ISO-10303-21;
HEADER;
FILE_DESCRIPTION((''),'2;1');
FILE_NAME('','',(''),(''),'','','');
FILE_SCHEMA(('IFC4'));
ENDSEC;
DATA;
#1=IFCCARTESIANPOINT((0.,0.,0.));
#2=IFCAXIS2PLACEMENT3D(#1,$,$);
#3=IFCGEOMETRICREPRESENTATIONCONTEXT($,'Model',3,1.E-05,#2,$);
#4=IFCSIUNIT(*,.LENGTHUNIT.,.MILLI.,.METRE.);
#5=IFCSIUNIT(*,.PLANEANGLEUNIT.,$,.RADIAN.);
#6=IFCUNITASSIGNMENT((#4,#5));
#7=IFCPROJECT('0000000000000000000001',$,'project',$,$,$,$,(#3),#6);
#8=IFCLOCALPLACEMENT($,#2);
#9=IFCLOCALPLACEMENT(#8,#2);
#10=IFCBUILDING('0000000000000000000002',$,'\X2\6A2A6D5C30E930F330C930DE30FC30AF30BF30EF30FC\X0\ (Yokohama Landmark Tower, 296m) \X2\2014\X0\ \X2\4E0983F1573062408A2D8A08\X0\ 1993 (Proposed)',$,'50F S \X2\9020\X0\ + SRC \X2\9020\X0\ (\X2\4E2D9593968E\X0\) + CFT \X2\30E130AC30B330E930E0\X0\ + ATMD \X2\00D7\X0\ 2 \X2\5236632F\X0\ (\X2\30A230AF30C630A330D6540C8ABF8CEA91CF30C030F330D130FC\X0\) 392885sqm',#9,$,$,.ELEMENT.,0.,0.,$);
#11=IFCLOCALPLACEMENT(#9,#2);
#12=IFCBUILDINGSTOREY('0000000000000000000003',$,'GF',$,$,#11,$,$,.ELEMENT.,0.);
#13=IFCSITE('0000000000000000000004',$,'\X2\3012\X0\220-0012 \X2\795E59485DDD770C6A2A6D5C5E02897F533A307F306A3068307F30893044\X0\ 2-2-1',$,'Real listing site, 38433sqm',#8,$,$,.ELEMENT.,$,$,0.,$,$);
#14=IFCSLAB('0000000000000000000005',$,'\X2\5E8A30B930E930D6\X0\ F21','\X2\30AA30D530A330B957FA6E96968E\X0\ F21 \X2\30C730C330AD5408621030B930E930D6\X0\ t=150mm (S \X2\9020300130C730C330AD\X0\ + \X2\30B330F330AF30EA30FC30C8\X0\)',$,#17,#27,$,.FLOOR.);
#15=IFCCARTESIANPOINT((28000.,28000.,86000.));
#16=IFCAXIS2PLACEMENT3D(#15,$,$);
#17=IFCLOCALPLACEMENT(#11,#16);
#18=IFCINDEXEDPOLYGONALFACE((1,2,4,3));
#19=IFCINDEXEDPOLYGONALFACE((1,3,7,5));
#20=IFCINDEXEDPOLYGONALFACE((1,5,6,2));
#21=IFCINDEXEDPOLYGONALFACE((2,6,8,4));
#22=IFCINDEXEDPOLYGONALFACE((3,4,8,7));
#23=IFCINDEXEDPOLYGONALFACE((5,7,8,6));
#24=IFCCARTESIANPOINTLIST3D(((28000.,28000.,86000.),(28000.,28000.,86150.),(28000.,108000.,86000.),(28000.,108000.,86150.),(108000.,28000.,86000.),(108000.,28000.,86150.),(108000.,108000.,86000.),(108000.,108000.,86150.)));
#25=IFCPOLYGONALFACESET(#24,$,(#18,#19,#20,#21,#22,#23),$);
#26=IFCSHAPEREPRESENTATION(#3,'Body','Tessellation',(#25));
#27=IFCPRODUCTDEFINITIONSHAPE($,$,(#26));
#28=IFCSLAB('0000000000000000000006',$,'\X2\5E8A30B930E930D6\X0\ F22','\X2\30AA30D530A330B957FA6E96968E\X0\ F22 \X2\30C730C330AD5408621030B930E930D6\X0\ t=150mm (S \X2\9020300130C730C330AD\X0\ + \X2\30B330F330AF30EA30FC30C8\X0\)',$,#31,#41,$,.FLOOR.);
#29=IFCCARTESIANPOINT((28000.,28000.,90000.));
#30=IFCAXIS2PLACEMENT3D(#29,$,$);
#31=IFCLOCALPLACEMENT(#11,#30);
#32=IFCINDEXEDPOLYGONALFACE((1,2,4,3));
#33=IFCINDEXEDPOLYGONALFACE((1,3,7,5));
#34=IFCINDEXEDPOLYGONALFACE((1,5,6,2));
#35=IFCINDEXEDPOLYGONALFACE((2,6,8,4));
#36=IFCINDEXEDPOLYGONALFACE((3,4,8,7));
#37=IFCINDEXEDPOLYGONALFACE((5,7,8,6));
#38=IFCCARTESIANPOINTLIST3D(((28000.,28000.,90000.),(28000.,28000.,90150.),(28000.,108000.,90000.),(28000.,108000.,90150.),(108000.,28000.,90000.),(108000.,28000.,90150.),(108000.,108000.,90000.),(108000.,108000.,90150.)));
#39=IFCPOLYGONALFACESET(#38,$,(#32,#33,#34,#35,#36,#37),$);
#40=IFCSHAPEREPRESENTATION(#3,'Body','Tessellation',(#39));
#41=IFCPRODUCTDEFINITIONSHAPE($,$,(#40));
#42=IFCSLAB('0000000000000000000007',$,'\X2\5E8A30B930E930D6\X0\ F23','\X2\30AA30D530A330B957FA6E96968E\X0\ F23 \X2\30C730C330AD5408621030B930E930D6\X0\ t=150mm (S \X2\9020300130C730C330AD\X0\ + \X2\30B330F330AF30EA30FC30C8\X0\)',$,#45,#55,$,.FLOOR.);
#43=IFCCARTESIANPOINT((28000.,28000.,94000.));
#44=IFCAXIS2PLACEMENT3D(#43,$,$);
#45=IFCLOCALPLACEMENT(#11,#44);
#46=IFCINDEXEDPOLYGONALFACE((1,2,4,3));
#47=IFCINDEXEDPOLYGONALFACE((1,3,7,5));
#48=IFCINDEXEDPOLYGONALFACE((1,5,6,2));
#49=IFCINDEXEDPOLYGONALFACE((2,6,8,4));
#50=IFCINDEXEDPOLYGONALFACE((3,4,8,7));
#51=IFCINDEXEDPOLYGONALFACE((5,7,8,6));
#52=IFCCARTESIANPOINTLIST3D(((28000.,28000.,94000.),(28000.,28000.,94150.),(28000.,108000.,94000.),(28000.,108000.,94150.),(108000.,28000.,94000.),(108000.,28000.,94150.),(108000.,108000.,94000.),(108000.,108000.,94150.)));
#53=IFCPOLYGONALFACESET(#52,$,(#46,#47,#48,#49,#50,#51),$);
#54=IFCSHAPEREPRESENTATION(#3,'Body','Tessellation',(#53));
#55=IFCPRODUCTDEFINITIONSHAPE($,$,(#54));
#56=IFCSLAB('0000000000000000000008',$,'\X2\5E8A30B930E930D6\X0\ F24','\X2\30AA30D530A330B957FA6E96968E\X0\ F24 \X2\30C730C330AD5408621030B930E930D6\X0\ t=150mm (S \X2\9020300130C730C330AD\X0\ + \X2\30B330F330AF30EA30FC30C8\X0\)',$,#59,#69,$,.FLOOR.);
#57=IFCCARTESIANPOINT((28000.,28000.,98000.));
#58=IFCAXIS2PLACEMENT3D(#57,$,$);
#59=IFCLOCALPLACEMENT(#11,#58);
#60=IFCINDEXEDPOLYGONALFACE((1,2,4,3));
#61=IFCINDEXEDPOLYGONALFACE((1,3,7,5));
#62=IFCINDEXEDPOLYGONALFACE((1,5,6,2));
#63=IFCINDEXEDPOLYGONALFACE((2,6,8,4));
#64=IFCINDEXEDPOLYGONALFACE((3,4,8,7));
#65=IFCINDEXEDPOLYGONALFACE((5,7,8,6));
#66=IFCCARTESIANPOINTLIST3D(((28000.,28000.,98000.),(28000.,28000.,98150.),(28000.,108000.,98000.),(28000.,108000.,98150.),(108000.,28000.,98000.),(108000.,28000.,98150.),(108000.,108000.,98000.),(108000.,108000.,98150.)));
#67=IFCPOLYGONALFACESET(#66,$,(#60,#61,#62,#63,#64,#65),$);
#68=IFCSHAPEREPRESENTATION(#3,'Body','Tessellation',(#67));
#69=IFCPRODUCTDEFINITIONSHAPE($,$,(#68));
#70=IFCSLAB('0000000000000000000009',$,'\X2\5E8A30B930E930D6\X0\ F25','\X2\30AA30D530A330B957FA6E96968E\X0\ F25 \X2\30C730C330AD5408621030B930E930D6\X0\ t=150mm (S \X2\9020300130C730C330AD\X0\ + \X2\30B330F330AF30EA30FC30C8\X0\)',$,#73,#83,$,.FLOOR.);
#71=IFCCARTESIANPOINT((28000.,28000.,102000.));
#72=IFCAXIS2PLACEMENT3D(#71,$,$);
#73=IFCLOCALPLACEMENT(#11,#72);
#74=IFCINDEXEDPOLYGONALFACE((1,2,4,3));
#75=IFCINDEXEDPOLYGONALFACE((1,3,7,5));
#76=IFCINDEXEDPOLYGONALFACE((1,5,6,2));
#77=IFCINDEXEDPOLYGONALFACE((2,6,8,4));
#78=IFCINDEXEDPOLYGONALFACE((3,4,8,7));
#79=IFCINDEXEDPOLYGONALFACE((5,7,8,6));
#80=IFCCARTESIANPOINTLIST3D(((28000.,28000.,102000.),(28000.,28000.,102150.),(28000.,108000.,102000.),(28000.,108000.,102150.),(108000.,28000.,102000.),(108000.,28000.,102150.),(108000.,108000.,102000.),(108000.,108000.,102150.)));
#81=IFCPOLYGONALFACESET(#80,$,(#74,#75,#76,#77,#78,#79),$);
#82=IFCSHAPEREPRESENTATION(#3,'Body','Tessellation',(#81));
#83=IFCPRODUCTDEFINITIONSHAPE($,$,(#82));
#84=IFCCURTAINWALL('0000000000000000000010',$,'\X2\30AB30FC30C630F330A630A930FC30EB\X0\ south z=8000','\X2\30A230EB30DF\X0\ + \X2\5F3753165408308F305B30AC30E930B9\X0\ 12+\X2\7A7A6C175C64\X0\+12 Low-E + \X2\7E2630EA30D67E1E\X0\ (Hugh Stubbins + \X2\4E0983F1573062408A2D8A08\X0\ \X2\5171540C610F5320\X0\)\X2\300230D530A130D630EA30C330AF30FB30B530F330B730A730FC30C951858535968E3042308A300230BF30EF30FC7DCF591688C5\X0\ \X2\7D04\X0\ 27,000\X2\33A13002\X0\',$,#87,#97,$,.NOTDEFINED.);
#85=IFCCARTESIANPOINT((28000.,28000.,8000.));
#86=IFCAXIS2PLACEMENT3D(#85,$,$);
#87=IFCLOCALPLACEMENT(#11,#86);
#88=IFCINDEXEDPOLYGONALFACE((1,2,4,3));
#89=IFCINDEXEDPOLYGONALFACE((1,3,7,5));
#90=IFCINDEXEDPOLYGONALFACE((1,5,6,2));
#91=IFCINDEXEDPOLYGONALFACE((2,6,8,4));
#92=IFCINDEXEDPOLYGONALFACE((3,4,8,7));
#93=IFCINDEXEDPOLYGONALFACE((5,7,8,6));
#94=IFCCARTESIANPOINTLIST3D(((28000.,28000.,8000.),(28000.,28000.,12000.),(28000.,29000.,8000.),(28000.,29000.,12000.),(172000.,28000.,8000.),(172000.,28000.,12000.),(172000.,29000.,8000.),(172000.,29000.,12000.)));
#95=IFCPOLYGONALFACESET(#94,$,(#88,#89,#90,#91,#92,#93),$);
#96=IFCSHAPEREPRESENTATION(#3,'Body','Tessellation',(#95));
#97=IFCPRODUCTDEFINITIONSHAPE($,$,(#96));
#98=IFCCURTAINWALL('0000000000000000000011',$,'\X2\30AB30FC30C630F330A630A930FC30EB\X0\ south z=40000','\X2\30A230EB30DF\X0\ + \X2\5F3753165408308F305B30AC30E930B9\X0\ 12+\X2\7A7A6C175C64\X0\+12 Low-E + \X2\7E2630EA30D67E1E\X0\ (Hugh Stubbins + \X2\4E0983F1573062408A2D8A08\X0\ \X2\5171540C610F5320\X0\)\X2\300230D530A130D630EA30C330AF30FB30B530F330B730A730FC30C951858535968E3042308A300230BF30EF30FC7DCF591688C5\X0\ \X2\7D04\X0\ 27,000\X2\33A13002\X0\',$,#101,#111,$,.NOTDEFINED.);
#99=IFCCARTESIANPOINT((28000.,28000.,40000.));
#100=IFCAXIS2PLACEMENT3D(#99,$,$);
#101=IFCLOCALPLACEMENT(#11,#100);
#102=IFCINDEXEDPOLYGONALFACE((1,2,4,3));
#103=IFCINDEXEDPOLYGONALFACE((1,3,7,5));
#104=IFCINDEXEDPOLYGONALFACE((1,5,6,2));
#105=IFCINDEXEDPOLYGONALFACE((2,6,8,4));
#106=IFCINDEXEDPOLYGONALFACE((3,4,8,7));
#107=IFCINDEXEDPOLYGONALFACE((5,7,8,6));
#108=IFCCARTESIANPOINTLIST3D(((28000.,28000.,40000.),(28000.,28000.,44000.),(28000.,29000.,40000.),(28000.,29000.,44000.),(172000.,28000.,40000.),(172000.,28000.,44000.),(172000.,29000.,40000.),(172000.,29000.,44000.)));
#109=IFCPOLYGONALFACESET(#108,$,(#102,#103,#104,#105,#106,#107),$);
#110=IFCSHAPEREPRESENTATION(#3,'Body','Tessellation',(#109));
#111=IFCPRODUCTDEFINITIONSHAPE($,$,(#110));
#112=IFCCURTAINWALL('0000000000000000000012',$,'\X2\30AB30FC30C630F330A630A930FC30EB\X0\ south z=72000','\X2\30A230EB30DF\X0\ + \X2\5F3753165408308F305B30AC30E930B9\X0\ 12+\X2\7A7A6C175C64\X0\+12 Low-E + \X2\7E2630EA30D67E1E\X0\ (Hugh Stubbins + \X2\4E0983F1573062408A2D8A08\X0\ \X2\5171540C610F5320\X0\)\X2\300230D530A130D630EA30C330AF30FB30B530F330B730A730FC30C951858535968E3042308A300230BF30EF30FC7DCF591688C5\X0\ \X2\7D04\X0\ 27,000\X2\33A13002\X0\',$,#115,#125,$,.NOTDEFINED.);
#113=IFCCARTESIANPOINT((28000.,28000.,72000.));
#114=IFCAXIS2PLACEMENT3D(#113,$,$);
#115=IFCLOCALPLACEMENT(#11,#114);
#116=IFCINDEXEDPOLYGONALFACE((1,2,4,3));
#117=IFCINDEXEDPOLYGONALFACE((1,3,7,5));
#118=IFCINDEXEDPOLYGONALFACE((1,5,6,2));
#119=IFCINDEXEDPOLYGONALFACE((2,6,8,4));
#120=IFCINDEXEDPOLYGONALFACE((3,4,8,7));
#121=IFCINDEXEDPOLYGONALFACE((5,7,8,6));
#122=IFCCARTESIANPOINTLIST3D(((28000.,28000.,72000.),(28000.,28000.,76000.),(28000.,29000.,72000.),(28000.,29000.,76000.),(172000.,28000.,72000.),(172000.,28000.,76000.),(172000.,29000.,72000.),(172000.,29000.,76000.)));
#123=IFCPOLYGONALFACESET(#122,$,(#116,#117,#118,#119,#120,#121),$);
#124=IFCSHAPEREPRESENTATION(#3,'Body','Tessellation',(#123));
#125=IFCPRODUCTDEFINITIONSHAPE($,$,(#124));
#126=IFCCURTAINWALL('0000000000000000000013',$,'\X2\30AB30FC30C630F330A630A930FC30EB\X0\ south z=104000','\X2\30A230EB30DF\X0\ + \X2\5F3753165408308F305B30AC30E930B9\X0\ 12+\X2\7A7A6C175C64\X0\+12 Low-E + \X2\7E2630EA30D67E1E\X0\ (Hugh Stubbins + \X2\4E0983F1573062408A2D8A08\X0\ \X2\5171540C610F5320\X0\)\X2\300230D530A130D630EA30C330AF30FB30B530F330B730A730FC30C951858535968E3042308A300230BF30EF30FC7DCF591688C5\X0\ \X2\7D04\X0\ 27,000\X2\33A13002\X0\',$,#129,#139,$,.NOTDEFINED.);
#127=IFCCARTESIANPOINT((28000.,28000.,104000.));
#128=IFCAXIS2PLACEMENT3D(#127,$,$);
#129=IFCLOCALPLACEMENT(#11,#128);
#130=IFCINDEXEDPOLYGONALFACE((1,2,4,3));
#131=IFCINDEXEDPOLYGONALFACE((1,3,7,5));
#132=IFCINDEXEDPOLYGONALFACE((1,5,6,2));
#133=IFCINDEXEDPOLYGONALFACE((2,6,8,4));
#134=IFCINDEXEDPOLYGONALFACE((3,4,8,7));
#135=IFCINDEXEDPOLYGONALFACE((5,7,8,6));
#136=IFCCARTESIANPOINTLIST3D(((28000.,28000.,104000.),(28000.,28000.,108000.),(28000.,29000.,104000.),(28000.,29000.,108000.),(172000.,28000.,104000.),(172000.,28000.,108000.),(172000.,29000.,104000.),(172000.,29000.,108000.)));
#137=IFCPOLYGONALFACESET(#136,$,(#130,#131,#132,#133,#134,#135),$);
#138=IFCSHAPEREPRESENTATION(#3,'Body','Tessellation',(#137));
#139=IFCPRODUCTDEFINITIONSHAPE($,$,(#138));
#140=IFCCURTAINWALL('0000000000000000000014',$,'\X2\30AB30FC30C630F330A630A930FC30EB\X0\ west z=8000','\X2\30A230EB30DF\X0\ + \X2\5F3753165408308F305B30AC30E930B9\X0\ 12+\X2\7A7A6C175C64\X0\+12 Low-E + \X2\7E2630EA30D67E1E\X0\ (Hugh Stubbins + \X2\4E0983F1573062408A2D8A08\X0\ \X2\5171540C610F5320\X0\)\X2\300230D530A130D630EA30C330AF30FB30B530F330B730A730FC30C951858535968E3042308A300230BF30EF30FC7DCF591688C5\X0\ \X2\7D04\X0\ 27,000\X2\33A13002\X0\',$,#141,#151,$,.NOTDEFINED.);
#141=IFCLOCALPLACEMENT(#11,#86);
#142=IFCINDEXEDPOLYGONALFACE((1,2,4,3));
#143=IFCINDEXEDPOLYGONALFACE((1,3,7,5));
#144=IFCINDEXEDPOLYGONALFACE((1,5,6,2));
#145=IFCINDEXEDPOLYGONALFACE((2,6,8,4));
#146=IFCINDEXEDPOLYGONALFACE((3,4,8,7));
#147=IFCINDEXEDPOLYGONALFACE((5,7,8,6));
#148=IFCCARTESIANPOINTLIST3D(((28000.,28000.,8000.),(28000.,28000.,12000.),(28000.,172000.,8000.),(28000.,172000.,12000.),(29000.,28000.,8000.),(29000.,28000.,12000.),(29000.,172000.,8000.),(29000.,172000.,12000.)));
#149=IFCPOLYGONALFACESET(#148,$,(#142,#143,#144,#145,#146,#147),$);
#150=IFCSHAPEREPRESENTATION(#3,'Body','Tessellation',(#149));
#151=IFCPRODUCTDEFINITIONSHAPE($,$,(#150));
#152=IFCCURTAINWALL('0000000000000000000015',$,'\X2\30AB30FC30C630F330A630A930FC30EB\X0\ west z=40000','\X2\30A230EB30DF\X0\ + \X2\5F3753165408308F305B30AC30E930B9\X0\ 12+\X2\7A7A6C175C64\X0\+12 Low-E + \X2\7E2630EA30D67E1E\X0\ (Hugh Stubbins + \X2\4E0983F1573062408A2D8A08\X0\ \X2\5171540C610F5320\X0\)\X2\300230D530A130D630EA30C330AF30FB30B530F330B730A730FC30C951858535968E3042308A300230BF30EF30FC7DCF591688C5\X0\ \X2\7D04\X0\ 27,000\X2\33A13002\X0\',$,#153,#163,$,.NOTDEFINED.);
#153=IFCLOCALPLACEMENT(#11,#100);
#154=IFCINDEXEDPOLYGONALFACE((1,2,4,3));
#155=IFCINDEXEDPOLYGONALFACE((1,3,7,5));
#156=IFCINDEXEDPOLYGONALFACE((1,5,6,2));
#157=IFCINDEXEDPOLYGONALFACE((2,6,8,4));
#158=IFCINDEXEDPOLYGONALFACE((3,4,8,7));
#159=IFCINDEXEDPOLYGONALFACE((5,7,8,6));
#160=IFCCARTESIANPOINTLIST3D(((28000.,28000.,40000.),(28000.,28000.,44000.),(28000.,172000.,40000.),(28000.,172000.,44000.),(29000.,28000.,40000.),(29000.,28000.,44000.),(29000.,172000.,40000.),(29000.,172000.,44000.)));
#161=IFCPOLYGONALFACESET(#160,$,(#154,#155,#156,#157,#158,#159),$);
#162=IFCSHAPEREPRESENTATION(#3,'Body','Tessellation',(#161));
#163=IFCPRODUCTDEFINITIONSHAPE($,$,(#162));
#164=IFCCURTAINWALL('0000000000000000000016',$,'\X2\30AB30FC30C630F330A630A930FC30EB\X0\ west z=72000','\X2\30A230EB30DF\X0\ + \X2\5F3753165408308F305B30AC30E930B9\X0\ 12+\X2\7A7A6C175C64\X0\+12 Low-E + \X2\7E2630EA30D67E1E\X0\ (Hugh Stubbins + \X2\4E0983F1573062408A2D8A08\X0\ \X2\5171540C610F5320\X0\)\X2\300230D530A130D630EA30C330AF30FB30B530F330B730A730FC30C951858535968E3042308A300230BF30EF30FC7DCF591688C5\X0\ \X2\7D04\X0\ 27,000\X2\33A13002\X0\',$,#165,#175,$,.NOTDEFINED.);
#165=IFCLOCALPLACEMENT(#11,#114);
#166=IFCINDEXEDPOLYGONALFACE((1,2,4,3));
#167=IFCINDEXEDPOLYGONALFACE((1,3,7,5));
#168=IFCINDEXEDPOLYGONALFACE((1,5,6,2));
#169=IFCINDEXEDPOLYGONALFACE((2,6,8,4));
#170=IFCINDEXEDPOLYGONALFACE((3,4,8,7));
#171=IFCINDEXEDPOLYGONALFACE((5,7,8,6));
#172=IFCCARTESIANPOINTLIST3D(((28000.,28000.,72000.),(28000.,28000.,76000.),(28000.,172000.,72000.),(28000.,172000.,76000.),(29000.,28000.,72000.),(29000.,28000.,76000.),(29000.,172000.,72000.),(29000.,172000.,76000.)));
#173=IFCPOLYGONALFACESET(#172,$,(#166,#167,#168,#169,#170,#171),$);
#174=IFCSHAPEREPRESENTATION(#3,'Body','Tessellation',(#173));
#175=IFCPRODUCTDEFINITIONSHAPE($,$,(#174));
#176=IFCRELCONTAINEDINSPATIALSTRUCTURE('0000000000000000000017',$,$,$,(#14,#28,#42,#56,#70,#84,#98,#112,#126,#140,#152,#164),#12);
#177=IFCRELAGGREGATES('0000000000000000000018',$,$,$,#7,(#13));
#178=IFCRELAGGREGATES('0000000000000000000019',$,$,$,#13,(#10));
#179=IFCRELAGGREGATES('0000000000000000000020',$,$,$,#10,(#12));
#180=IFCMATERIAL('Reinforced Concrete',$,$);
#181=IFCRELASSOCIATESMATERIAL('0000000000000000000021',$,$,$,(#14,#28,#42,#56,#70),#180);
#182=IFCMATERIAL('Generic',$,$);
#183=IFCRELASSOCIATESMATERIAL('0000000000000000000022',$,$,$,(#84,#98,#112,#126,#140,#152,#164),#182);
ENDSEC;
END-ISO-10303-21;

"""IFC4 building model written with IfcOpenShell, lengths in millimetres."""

from ifc_helpers import new_model, si_unit, frame, frame_2d, origin, place, context, project, spatial, rectangle, extrude, material, element, save


model = new_model("IFC4")

# Units and contexts
model_context = context("Model", 3, precision=1e-05, world=origin())
ifc_project = project(units=[si_unit("LENGTHUNIT", "METRE", prefix="MILLI"), si_unit("PLANEANGLEUNIT", "RADIAN")], contexts=[model_context])

# Site, building, storey
site_placement = place(None, origin())
site = spatial("IfcSite", under=ifc_project, at=site_placement, Name="〒220-0012 神奈川県横浜市西区みなとみらい 2-2-1", ObjectType="Real listing site, 38433sqm", CompositionType="ELEMENT", RefElevation=0.0)
building_placement = place(site_placement, origin())
building = spatial("IfcBuilding", under=site, at=building_placement, Name="横浜ランドマークタワー (Yokohama Landmark Tower, 296m) — 三菱地所設計 1993 (Proposed)", ObjectType="50F S 造 + SRC 造 (中間階) + CFT メガコラム + ATMD × 2 制振 (アクティブ同調質量ダンパー) 392885sqm", CompositionType="ELEMENT", ElevationOfRefHeight=0.0, ElevationOfTerrain=0.0)
storey_placement = place(building_placement, origin())
storey = spatial("IfcBuildingStorey", under=building, at=storey_placement, Name="GF", CompositionType="ELEMENT", Elevation=0.0)

# Shared definitions
ifc_material_1 = material(Name="Reinforced Concrete")

# Slabs
slab_1_placement = place(storey_placement, frame((28000.0, 28000.0, 86000.0)))
element("IfcSlab", 1, at=slab_1_placement, inside=storey, material=ifc_material_1, Name="床スラブ F21", Description="オフィス基準階 F21 デッキ合成スラブ t=150mm (S 造、デッキ + コンクリート)", PredefinedType="FLOOR", context=model_context, shape_type="SweptSolid", body=[
    extrude(rectangle(XDim=80000.0, YDim=80000.0, at=frame_2d((40000.0, 40000.0))), frame((28000.0, 28000.0, 86000.0)), (0.0, 0.0, 1.0), 150.0),
])
slab_2_placement = place(storey_placement, frame((28000.0, 28000.0, 90000.0)))
element("IfcSlab", 2, at=slab_2_placement, inside=storey, material=ifc_material_1, Name="床スラブ F22", Description="オフィス基準階 F22 デッキ合成スラブ t=150mm (S 造、デッキ + コンクリート)", PredefinedType="FLOOR", context=model_context, shape_type="SweptSolid", body=[
    extrude(rectangle(XDim=80000.0, YDim=80000.0, at=frame_2d((40000.0, 40000.0))), frame((28000.0, 28000.0, 90000.0)), (0.0, 0.0, 1.0), 150.0),
])
slab_3_placement = place(storey_placement, frame((28000.0, 28000.0, 94000.0)))
element("IfcSlab", 3, at=slab_3_placement, inside=storey, material=ifc_material_1, Name="床スラブ F23", Description="オフィス基準階 F23 デッキ合成スラブ t=150mm (S 造、デッキ + コンクリート)", PredefinedType="FLOOR", context=model_context, shape_type="SweptSolid", body=[
    extrude(rectangle(XDim=80000.0, YDim=80000.0, at=frame_2d((40000.0, 40000.0))), frame((28000.0, 28000.0, 94000.0)), (0.0, 0.0, 1.0), 150.0),
])
slab_4_placement = place(storey_placement, frame((28000.0, 28000.0, 98000.0)))
element("IfcSlab", 4, at=slab_4_placement, inside=storey, material=ifc_material_1, Name="床スラブ F24", Description="オフィス基準階 F24 デッキ合成スラブ t=150mm (S 造、デッキ + コンクリート)", PredefinedType="FLOOR", context=model_context, shape_type="SweptSolid", body=[
    extrude(rectangle(XDim=80000.0, YDim=80000.0, at=frame_2d((40000.0, 40000.0))), frame((28000.0, 28000.0, 98000.0)), (0.0, 0.0, 1.0), 150.0),
])
slab_5_placement = place(storey_placement, frame((28000.0, 28000.0, 102000.0)))
element("IfcSlab", 5, at=slab_5_placement, inside=storey, material=ifc_material_1, Name="床スラブ F25", Description="オフィス基準階 F25 デッキ合成スラブ t=150mm (S 造、デッキ + コンクリート)", PredefinedType="FLOOR", context=model_context, shape_type="SweptSolid", body=[
    extrude(rectangle(XDim=80000.0, YDim=80000.0, at=frame_2d((40000.0, 40000.0))), frame((28000.0, 28000.0, 102000.0)), (0.0, 0.0, 1.0), 150.0),
])

# Curtain walls
ifc_material_2 = material(Name="Generic")
curtain_wall_1_placement = place(storey_placement, frame((28000.0, 28000.0, 8000.0)))
element("IfcCurtainWall", 6, at=curtain_wall_1_placement, inside=storey, material=ifc_material_2, Name="カーテンウォール south z=8000", Description="アルミ + 強化合わせガラス 12+空気層+12 Low-E + 縦リブ縞 (Hugh Stubbins + 三菱地所設計 共同意匠)。ファブリック・サンシェード内蔵階あり。タワー総外装 約 27,000㎡。", PredefinedType="NOTDEFINED", context=model_context, shape_type="SweptSolid", body=[
    extrude(rectangle(XDim=144000.0, YDim=1000.0, at=frame_2d((72000.0, 500.0))), frame((28000.0, 28000.0, 8000.0)), (0.0, 0.0, 1.0), 4000.0),
])
curtain_wall_2_placement = place(storey_placement, frame((28000.0, 28000.0, 40000.0)))
element("IfcCurtainWall", 7, at=curtain_wall_2_placement, inside=storey, material=ifc_material_2, Name="カーテンウォール south z=40000", Description="アルミ + 強化合わせガラス 12+空気層+12 Low-E + 縦リブ縞 (Hugh Stubbins + 三菱地所設計 共同意匠)。ファブリック・サンシェード内蔵階あり。タワー総外装 約 27,000㎡。", PredefinedType="NOTDEFINED", context=model_context, shape_type="SweptSolid", body=[
    extrude(rectangle(XDim=144000.0, YDim=1000.0, at=frame_2d((72000.0, 500.0))), frame((28000.0, 28000.0, 40000.0)), (0.0, 0.0, 1.0), 4000.0),
])
curtain_wall_3_placement = place(storey_placement, frame((28000.0, 28000.0, 72000.0)))
element("IfcCurtainWall", 8, at=curtain_wall_3_placement, inside=storey, material=ifc_material_2, Name="カーテンウォール south z=72000", Description="アルミ + 強化合わせガラス 12+空気層+12 Low-E + 縦リブ縞 (Hugh Stubbins + 三菱地所設計 共同意匠)。ファブリック・サンシェード内蔵階あり。タワー総外装 約 27,000㎡。", PredefinedType="NOTDEFINED", context=model_context, shape_type="SweptSolid", body=[
    extrude(rectangle(XDim=144000.0, YDim=1000.0, at=frame_2d((72000.0, 500.0))), frame((28000.0, 28000.0, 72000.0)), (0.0, 0.0, 1.0), 4000.0),
])
curtain_wall_4_placement = place(storey_placement, frame((28000.0, 28000.0, 104000.0)))
element("IfcCurtainWall", 9, at=curtain_wall_4_placement, inside=storey, material=ifc_material_2, Name="カーテンウォール south z=104000", Description="アルミ + 強化合わせガラス 12+空気層+12 Low-E + 縦リブ縞 (Hugh Stubbins + 三菱地所設計 共同意匠)。ファブリック・サンシェード内蔵階あり。タワー総外装 約 27,000㎡。", PredefinedType="NOTDEFINED", context=model_context, shape_type="SweptSolid", body=[
    extrude(rectangle(XDim=144000.0, YDim=1000.0, at=frame_2d((72000.0, 500.0))), frame((28000.0, 28000.0, 104000.0)), (0.0, 0.0, 1.0), 4000.0),
])
curtain_wall_5_placement = place(storey_placement, frame((28000.0, 28000.0, 8000.0)))
element("IfcCurtainWall", 10, at=curtain_wall_5_placement, inside=storey, material=ifc_material_2, Name="カーテンウォール west z=8000", Description="アルミ + 強化合わせガラス 12+空気層+12 Low-E + 縦リブ縞 (Hugh Stubbins + 三菱地所設計 共同意匠)。ファブリック・サンシェード内蔵階あり。タワー総外装 約 27,000㎡。", PredefinedType="NOTDEFINED", context=model_context, shape_type="SweptSolid", body=[
    extrude(rectangle(XDim=1000.0, YDim=144000.0, at=frame_2d((500.0, 72000.0))), frame((28000.0, 28000.0, 8000.0)), (0.0, 0.0, 1.0), 4000.0),
])
curtain_wall_6_placement = place(storey_placement, frame((28000.0, 28000.0, 40000.0)))
element("IfcCurtainWall", 11, at=curtain_wall_6_placement, inside=storey, material=ifc_material_2, Name="カーテンウォール west z=40000", Description="アルミ + 強化合わせガラス 12+空気層+12 Low-E + 縦リブ縞 (Hugh Stubbins + 三菱地所設計 共同意匠)。ファブリック・サンシェード内蔵階あり。タワー総外装 約 27,000㎡。", PredefinedType="NOTDEFINED", context=model_context, shape_type="SweptSolid", body=[
    extrude(rectangle(XDim=1000.0, YDim=144000.0, at=frame_2d((500.0, 72000.0))), frame((28000.0, 28000.0, 40000.0)), (0.0, 0.0, 1.0), 4000.0),
])
curtain_wall_7_placement = place(storey_placement, frame((28000.0, 28000.0, 72000.0)))
element("IfcCurtainWall", 12, at=curtain_wall_7_placement, inside=storey, material=ifc_material_2, Name="カーテンウォール west z=72000", Description="アルミ + 強化合わせガラス 12+空気層+12 Low-E + 縦リブ縞 (Hugh Stubbins + 三菱地所設計 共同意匠)。ファブリック・サンシェード内蔵階あり。タワー総外装 約 27,000㎡。", PredefinedType="NOTDEFINED", context=model_context, shape_type="SweptSolid", body=[
    extrude(rectangle(XDim=1000.0, YDim=144000.0, at=frame_2d((500.0, 72000.0))), frame((28000.0, 28000.0, 72000.0)), (0.0, 0.0, 1.0), 4000.0),
])

save(model, "model.ifc")
